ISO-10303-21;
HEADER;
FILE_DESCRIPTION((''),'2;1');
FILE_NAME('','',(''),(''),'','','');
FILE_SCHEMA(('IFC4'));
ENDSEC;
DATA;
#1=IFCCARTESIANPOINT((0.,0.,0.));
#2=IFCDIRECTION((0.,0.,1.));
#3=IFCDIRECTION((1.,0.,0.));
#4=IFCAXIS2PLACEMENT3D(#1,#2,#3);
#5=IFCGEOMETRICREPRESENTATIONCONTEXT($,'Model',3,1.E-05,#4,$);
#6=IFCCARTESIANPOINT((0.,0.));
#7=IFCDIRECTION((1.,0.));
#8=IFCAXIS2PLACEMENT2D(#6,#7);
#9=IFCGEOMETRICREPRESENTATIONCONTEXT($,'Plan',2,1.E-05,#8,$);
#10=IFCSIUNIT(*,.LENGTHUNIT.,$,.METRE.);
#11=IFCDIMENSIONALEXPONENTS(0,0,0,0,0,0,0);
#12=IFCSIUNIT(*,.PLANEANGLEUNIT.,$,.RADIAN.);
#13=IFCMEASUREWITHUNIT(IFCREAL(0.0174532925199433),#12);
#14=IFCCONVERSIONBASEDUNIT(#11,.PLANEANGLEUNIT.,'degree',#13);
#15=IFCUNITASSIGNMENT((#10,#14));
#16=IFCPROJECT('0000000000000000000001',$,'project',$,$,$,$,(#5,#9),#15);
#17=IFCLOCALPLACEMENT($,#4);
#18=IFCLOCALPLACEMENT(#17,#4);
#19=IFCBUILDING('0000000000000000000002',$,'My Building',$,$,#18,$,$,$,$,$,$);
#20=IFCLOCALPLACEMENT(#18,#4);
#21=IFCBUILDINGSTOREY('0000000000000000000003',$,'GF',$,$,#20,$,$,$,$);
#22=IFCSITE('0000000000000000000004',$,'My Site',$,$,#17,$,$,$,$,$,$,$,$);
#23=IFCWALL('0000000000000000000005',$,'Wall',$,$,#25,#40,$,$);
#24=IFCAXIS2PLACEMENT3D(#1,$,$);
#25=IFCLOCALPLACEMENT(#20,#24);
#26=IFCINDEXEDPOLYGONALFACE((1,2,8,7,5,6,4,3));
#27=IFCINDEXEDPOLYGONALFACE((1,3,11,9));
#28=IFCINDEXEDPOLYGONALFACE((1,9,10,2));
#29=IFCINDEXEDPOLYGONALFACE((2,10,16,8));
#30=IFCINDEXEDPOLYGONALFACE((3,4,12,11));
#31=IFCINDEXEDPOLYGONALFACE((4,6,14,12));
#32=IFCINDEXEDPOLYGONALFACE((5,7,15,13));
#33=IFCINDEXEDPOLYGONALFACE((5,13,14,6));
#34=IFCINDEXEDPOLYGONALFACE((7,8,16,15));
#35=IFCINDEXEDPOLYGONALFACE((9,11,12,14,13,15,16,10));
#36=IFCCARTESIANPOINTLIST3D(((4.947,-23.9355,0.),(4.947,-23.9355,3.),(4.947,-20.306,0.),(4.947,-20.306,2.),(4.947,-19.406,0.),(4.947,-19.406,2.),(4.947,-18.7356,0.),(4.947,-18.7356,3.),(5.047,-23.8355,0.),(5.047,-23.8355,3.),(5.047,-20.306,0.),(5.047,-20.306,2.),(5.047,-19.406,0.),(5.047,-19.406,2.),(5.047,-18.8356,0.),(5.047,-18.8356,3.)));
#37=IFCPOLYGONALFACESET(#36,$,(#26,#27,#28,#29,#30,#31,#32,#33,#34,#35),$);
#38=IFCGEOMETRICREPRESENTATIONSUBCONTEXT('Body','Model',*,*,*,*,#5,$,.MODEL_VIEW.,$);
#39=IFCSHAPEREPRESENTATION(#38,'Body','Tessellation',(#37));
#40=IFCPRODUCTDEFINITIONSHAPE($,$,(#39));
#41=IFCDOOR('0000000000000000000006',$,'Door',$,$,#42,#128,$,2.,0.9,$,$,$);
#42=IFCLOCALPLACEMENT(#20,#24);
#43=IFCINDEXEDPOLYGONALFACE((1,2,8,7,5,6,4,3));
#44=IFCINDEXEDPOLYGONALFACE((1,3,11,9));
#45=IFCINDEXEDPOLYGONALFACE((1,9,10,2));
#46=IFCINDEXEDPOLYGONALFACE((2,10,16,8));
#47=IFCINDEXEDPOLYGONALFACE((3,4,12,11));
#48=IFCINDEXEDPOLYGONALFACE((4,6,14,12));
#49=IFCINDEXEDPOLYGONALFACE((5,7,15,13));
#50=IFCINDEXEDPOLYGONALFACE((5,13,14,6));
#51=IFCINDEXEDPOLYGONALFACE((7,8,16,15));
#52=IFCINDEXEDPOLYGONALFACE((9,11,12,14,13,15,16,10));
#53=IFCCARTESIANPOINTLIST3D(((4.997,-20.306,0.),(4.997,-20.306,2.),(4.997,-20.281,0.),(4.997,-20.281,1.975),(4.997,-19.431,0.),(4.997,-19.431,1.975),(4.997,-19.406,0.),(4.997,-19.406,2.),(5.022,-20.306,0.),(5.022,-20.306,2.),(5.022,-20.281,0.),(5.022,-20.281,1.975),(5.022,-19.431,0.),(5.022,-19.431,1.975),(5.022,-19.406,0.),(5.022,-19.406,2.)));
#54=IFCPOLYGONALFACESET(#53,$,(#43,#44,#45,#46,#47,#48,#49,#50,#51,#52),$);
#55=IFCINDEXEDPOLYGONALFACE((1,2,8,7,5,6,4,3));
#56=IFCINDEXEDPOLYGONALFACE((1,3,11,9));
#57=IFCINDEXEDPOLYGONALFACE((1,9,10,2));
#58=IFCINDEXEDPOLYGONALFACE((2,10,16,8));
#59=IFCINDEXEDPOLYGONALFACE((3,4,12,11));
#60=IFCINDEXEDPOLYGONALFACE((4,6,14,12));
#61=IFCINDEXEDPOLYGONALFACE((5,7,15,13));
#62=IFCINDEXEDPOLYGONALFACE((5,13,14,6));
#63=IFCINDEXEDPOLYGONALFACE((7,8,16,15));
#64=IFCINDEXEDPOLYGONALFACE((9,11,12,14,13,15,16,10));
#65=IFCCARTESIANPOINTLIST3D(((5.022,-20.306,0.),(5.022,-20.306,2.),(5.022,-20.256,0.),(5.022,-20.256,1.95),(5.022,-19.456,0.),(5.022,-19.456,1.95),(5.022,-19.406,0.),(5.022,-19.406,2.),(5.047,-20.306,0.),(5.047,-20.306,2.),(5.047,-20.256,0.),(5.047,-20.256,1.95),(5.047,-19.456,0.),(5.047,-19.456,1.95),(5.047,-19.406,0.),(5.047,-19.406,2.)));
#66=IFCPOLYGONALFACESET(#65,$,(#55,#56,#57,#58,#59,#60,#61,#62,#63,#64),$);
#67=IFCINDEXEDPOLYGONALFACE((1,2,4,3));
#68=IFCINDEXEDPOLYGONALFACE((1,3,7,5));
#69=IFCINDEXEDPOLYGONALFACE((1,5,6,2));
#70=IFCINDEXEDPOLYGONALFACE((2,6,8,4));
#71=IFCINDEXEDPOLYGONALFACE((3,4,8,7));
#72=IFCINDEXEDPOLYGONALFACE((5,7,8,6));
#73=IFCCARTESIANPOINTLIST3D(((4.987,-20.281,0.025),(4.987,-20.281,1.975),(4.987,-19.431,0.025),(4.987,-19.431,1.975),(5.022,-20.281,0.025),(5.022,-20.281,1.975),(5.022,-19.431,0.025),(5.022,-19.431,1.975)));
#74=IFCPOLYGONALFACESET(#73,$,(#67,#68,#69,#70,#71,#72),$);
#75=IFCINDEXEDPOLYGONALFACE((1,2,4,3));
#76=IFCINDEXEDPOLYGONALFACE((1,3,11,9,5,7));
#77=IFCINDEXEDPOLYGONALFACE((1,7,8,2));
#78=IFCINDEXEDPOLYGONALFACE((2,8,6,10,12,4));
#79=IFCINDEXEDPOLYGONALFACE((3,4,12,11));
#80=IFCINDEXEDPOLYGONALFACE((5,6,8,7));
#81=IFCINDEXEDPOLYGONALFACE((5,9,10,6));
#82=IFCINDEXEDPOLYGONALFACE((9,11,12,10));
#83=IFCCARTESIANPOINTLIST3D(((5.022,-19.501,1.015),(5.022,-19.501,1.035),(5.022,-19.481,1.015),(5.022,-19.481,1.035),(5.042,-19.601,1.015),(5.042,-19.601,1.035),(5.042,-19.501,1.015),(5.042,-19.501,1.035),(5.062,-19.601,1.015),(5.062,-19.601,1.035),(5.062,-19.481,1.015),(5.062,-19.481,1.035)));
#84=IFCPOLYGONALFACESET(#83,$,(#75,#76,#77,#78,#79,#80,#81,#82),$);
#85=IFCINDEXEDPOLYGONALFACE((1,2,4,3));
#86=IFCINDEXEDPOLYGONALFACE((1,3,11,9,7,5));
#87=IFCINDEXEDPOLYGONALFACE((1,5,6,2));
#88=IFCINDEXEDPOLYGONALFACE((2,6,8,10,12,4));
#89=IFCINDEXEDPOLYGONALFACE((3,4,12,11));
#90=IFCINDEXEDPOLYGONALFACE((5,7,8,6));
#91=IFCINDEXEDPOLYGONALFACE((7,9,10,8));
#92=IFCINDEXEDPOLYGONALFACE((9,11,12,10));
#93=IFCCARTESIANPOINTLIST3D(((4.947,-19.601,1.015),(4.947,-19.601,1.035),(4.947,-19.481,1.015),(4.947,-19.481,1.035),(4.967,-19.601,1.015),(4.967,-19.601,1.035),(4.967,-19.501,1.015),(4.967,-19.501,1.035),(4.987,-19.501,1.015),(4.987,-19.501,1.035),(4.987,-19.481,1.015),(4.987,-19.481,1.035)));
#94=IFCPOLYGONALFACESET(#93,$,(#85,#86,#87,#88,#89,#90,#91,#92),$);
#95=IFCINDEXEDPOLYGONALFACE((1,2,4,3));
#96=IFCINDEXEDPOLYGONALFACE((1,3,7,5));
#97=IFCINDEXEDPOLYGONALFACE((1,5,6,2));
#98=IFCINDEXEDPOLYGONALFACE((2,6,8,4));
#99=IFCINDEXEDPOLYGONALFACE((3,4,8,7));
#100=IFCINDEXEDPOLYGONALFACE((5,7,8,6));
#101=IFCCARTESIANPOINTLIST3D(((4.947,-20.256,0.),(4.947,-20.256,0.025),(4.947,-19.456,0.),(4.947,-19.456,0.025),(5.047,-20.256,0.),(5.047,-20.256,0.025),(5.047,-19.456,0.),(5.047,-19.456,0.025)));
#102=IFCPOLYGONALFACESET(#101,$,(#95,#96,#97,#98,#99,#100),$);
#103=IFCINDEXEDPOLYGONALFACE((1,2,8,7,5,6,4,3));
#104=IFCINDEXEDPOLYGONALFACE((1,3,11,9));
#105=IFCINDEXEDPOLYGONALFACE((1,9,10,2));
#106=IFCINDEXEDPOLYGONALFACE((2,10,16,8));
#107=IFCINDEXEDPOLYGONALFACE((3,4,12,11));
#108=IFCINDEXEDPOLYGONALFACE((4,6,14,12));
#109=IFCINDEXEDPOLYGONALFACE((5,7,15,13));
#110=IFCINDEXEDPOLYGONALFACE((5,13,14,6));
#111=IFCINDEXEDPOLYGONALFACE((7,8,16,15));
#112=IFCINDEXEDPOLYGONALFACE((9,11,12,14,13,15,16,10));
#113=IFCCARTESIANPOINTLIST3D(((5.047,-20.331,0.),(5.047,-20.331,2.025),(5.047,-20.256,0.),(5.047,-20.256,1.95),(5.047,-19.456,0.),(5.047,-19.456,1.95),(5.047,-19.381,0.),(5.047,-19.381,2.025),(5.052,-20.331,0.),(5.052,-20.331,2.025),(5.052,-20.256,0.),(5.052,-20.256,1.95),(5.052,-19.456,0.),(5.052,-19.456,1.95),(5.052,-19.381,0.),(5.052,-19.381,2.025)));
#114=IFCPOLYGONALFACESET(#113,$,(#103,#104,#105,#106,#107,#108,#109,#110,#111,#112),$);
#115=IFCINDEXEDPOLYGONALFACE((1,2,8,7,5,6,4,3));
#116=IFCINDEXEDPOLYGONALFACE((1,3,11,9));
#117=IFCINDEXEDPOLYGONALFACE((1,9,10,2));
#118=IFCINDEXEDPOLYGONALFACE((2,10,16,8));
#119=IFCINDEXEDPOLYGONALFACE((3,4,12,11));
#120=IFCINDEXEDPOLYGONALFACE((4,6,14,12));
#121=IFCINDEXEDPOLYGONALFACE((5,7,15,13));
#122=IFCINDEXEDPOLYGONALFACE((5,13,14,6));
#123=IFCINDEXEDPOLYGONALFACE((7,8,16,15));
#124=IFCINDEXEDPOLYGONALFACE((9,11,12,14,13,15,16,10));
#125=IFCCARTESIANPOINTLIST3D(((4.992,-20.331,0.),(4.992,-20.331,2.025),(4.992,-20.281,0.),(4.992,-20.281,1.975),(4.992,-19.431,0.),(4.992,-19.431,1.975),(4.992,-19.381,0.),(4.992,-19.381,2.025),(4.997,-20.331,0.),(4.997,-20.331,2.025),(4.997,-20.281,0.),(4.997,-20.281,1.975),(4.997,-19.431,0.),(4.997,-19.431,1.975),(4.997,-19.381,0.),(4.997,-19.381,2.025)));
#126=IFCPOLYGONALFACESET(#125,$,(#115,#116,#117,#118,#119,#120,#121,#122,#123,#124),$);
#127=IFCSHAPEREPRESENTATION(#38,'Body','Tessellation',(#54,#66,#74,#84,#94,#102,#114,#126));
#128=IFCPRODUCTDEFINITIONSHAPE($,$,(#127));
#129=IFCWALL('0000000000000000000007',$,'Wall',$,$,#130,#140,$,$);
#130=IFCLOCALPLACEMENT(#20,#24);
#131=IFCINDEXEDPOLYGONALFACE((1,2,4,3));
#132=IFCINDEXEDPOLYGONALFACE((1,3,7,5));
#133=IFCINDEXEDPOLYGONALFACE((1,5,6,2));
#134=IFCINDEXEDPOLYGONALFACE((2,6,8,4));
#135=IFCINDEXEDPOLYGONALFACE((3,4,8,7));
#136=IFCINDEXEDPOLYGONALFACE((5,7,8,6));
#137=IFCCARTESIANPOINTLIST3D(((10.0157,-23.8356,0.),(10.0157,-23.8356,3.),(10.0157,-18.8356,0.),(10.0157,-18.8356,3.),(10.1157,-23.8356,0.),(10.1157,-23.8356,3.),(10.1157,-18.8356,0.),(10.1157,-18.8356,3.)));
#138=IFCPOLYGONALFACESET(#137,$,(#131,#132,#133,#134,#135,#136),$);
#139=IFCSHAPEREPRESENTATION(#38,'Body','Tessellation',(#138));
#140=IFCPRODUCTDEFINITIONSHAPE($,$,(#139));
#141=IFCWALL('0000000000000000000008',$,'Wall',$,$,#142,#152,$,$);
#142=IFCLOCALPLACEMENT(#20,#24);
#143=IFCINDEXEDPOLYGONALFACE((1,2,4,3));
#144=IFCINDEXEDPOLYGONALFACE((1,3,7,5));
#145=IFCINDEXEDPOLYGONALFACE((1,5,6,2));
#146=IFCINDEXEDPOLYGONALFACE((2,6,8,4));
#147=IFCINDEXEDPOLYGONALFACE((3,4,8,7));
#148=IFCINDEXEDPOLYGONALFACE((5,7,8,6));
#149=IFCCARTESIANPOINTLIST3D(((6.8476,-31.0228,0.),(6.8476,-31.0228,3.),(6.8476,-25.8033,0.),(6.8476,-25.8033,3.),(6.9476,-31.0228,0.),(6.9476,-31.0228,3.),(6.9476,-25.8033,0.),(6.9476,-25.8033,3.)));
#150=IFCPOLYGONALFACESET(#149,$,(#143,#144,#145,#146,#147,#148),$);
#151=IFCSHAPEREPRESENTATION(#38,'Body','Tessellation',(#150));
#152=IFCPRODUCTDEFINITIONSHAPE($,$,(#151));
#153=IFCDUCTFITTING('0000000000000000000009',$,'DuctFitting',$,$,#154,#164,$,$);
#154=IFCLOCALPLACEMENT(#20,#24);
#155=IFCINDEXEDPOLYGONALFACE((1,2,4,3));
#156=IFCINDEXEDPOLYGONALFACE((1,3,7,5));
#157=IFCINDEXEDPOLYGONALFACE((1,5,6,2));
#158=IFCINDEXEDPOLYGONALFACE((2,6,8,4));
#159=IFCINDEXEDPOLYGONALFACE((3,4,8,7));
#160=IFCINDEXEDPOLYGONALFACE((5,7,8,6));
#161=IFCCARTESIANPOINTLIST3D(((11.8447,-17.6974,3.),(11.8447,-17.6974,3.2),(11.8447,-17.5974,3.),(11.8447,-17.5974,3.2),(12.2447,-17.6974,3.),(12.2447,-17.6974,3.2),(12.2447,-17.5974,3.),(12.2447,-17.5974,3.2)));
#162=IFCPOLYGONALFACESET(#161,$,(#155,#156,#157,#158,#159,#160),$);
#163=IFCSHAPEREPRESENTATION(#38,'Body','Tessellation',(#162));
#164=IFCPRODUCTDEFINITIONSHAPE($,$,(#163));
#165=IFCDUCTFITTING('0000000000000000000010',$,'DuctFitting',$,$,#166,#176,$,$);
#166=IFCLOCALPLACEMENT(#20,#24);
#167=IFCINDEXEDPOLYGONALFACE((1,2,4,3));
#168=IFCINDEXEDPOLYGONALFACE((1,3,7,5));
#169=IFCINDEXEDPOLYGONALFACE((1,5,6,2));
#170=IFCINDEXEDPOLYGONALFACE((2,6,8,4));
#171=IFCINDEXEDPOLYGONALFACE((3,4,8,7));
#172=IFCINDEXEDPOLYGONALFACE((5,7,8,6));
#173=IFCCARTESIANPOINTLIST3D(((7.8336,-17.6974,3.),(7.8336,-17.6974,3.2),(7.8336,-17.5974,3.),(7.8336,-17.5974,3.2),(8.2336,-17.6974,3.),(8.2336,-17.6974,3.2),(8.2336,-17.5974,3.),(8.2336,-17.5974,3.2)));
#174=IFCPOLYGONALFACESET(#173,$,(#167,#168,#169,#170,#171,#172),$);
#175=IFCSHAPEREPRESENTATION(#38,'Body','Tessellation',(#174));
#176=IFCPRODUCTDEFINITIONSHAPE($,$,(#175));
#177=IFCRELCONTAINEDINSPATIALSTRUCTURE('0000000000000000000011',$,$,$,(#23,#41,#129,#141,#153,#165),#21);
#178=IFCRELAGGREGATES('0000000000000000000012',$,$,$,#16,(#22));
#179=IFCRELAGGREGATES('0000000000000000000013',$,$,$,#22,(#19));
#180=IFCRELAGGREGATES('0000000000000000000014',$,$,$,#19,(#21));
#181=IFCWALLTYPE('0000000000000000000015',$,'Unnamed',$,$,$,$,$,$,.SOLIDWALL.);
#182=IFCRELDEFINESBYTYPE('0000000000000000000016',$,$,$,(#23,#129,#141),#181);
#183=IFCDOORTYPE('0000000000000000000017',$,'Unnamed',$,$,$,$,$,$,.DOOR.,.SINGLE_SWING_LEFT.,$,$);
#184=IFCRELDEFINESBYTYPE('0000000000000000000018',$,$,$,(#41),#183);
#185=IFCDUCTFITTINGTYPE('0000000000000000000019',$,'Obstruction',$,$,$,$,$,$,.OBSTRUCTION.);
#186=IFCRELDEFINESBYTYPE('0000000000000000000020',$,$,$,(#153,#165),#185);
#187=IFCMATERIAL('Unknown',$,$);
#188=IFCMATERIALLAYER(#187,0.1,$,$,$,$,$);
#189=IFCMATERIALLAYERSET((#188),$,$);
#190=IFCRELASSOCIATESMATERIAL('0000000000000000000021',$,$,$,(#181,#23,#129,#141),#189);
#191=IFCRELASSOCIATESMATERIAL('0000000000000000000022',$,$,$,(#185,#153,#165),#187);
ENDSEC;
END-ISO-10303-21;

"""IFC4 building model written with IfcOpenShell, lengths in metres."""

from ifc_helpers import new_model, entity, si_unit, converted_unit, frame, origin_with_axes, origin_2d_with_axis, place, context, subcontext, project, spatial, line, indexed_curve, rectangle, outline, extrude, shape, source, transform, mapped, material, layer, layer_set, layer_usage, material_profile, profile_set, profile_usage, type_object, type_shapes, element, fill, save


model = new_model("IFC4")

# Units and contexts
model_context = context("Model", 3, precision=1e-05, world=origin_with_axes())
plan_context = context("Plan", 2, precision=1e-05, world=origin_2d_with_axis())
body_context_1 = subcontext(model_context, "Body", "Model", "MODEL_VIEW")
body_context_2 = subcontext(plan_context, "Body", "Plan", "PLAN_VIEW")
ifc_project = project(units=[si_unit("LENGTHUNIT", "METRE"), converted_unit("PLANEANGLEUNIT", "degree", entity("IfcReal", 0.0174532925199433), si_unit("PLANEANGLEUNIT", "RADIAN"), dimensions=[0, 0, 0, 0, 0, 0, 0])], contexts=[model_context, plan_context])

# Site, building, storey
site_placement = place(None, origin_with_axes())
site = spatial("IfcSite", under=ifc_project, at=site_placement, Name="My Site")
building_placement = place(site_placement, origin_with_axes())
building = spatial("IfcBuilding", under=site, at=building_placement, Name="My Building")
storey_placement = place(building_placement, origin_with_axes())
storey = spatial("IfcBuildingStorey", under=building, at=storey_placement, Name="GF")

# Shared definitions
ifc_material = material(Name="Unknown")
ifc_layer = layer(ifc_material, 0.1)
ifc_layer_set = layer_set([ifc_layer])
wall_type = type_object("IfcWallType", Name="Unnamed", PredefinedType="SOLIDWALL", material=ifc_layer_set)

# Shared definitions
shared_shape_1 = source(origin_with_axes(), body_context_1, "Body", "SweptSolid", [
    extrude(outline(indexed_curve([(0.0, 0.0), (0.9, 0.0), (0.9, 2.0), (0.0, 2.0)], segments=[line(1, 2, 3, 4, 1)])), frame((0.0, -0.6, 0.0), z_axis=(0.0, -1.0, 0.0), x_axis=(1.0, 0.0, 0.0)), (0.0, 0.0, -1.0), 1.2),
])
door_type = type_object("IfcDoorType", Name="Unnamed", OperationType="SINGLE_SWING_LEFT", PredefinedType="DOOR")
shared_shape_2 = source(origin_with_axes(), body_context_1, "Body", "SweptSolid", [
    extrude(outline(indexed_curve([(0.0, 0.0), (0.0, 2.0), (0.9, 2.0), (0.9, 0.0), (0.875, 0.0), (0.875, 1.975), (0.025, 1.975), (0.025, 0.0)], segments=[line(1, 2, 3, 4, 5, 6, 7, 8, 1)])), frame((0.0, 0.025, 0.0), z_axis=(0.0, -1.0, 0.0), x_axis=(1.0, 0.0, 0.0)), (0.0, 0.0, -1.0), 0.025),
    extrude(outline(indexed_curve([(0.0, 0.0), (0.0, 2.0), (0.9, 2.0), (0.9, 0.0), (0.85, 0.0), (0.85, 1.95), (0.05, 1.95), (0.05, 0.0)], segments=[line(1, 2, 3, 4, 5, 6, 7, 8, 1)])), frame((0.0, 0.0, 0.0), z_axis=(0.0, -1.0, 0.0), x_axis=(1.0, 0.0, 0.0)), (0.0, 0.0, -1.0), 0.025),
    extrude(outline(indexed_curve([(0.0, 0.0), (0.85, 0.0), (0.85, 0.035), (0.0, 0.035)], segments=[line(1, 2, 3, 4, 1)])), frame((0.025, 0.025, 0.025), z_axis=(0.0, 0.0, 1.0), x_axis=(1.0, 0.0, 0.0)), (0.0, 0.0, 1.0), 1.95),
    extrude(outline(indexed_curve([(0.0, 0.0), (0.0, -0.04), (-0.12, -0.04), (-0.12, -0.02), (-0.02, -0.02), (-0.02, 0.0)], segments=[line(1, 2, 3, 4, 5, 6, 1)])), frame((0.825, 0.025, 1.015), z_axis=(0.0, 0.0, 1.0), x_axis=(1.0, 0.0, 0.0)), (0.0, 0.0, 1.0), 0.02),
    extrude(outline(indexed_curve([(0.0, 0.0), (0.0, 0.04), (-0.12, 0.04), (-0.12, 0.02), (-0.02, 0.02), (-0.02, 0.0)], segments=[line(1, 2, 3, 4, 5, 6, 1)])), frame((0.825, 0.06, 1.015), z_axis=(0.0, 0.0, 1.0), x_axis=(1.0, 0.0, 0.0)), (0.0, 0.0, 1.0), 0.02),
    extrude(outline(indexed_curve([(0.0, 0.0), (0.8, 0.0), (0.8, 0.1), (0.0, 0.1)], segments=[line(1, 2, 3, 4, 1)])), frame((0.05, 0.0, 0.0), z_axis=(0.0, 0.0, 1.0), x_axis=(1.0, 0.0, 0.0)), (0.0, 0.0, 1.0), 0.025),
    extrude(outline(indexed_curve([(0.0, 0.0), (0.0, 2.025), (0.95, 2.025), (0.95, 0.0), (0.875, 0.0), (0.875, 1.95), (0.075, 1.95), (0.075, 0.0)], segments=[line(1, 2, 3, 4, 5, 6, 7, 8, 1)])), frame((-0.025, -0.005, 0.0), z_axis=(0.0, -1.0, 0.0), x_axis=(1.0, 0.0, 0.0)), (0.0, 0.0, -1.0), 0.005),
    extrude(outline(indexed_curve([(0.0, 0.0), (0.0, 2.025), (0.95, 2.025), (0.95, 0.0), (0.9, 0.0), (0.9, 1.975), (0.05, 1.975), (0.05, 0.0)], segments=[line(1, 2, 3, 4, 5, 6, 7, 8, 1)])), frame((-0.025, 0.05, 0.0), z_axis=(0.0, -1.0, 0.0), x_axis=(1.0, 0.0, 0.0)), (0.0, 0.0, -1.0), 0.005),
])
shared_shape_3 = source(origin_with_axes(), body_context_2, "Body", "Curve2D", [
    entity("IfcIndexedPolyCurve", entity("IfcCartesianPointList2D", [[0.0, 0.0], [0.0, 0.05], [0.025, 0.05], [0.025, 0.025], [0.05, 0.025], [0.05, 0.0]]), [entity("IfcLineIndex", [1, 2, 3, 4, 5, 6, 1])]),
    entity("IfcIndexedPolyCurve", entity("IfcCartesianPointList2D", [[0.9, 0.0], [0.9, 0.05], [0.875, 0.05], [0.875, 0.025], [0.85, 0.025], [0.85, 0.0]]), [entity("IfcLineIndex", [1, 2, 3, 4, 5, 6, 1])]),
    entity("IfcTrimmedCurve", entity("IfcEllipse", entity("IfcAxis2Placement2D", entity("IfcCartesianPoint", [0.06, 0.05]), entity("IfcDirection", [1.0, 0.0])), 0.815, 0.85), [entity("IfcCartesianPoint", [0.875, 0.05])], [entity("IfcCartesianPoint", [0.06, 0.9])], True, "CARTESIAN"),
    entity("IfcIndexedPolyCurve", entity("IfcCartesianPointList2D", [[0.025, 0.05], [0.06, 0.05], [0.06, 0.9], [0.025, 0.9]]), [entity("IfcLineIndex", [1, 2, 3, 4, 1])]),
])
type_shapes(door_type, [shared_shape_2, shared_shape_3])

# Wall, opening, door
ifc_layer_usage_1 = layer_usage(ifc_layer_set, "AXIS2", "POSITIVE", 0.0)
wall_1_placement = place(storey_placement, frame((5.047, -23.8355, 0.0), z_axis=(0.0, 0.0, 1.0), x_axis=(0.0, 1.0, 0.0)))
wall_1 = element("IfcWall", 1, at=wall_1_placement, inside=storey, type_object=wall_type, material=ifc_layer_usage_1, Name="Wall", context=body_context_1, shape_type="SweptSolid", body=[
    extrude(outline(indexed_curve([(0.0, 0.0), (-0.1, 0.1), (5.1, 0.1), (5.0, 0.0)], segments=[line(1, 2, 3, 4, 1)])), origin_with_axes(), (0.0, 0.0, 1.0), 3.0),
])
opening_1_placement = place(wall_1_placement, frame((3.5295, 0.0, 0.0), z_axis=(0.0, 0.0, 1.0), x_axis=(1.0, 0.0, 0.0)))
opening_1 = element("IfcOpeningElement", 2, at=opening_1_placement, cuts=wall_1, PredefinedType="OPENING", context=body_context_1, shape_type="MappedRepresentation", body=[
    mapped(shared_shape_1, transform((0.0, 0.0, 0.0), x_axis=(1.0, 0.0, 0.0), y_axis=(0.0, 1.0, 0.0), z_axis=(0.0, 0.0, 1.0), scale=1.0)),
])
door_1_placement = place(opening_1_placement, frame((0.0, 0.0, 0.0), z_axis=(0.0, 0.0, 1.0), x_axis=(1.0, 0.0, 0.0)))
door_1 = element("IfcDoor", 3, at=door_1_placement, inside=storey, type_object=door_type, Name="Door", OverallHeight=2.0, OverallWidth=0.9, shapes=[
    shape(body_context_1, "Body", "MappedRepresentation", [mapped(shared_shape_2, transform((0.0, 0.0, 0.0), x_axis=(1.0, 0.0, 0.0), y_axis=(0.0, 1.0, 0.0), z_axis=(0.0, 0.0, 1.0), scale=1.0))]),
    shape(body_context_2, "Body", "MappedRepresentation", [mapped(shared_shape_3, transform((0.0, 0.0, 0.0), x_axis=(1.0, 0.0, 0.0), y_axis=(0.0, 1.0, 0.0), z_axis=(0.0, 0.0, 1.0), scale=1.0))]),
])
fill(opening_1, door_1)

# Walls
ifc_layer_usage_2 = layer_usage(ifc_layer_set, "AXIS2", "POSITIVE", 0.0)
wall_2_placement = place(storey_placement, frame((10.0157, -18.8356, 0.0), z_axis=(0.0, 0.0, 1.0), x_axis=(0.0, -1.0, 0.0)))
element("IfcWall", 4, at=wall_2_placement, inside=storey, type_object=wall_type, material=ifc_layer_usage_2, Name="Wall", context=body_context_1, shape_type="SweptSolid", body=[
    extrude(outline(indexed_curve([(0.0, 0.0), (0.0, 0.1), (5.0, 0.1), (5.0, 0.0)], segments=[line(1, 2, 3, 4, 1)])), origin_with_axes(), (0.0, 0.0, 1.0), 3.0),
])
ifc_layer_usage_3 = layer_usage(ifc_layer_set, "AXIS2", "POSITIVE", 0.0)
wall_3_placement = place(storey_placement, frame((6.8476, -25.8033, 0.0), z_axis=(0.0, 0.0, 1.0), x_axis=(0.0, -1.0, 0.0)))
element("IfcWall", 5, at=wall_3_placement, inside=storey, type_object=wall_type, material=ifc_layer_usage_3, Name="Wall", context=body_context_1, shape_type="SweptSolid", body=[
    extrude(outline(indexed_curve([(0.0, 0.0), (0.0, 0.1), (5.2195, 0.1), (5.2195, 0.0)], segments=[line(1, 2, 3, 4, 1)])), origin_with_axes(), (0.0, 0.0, 1.0), 3.0),
])

# Duct fittings
ifc_material_profile = material_profile(ifc_material, rectangle(XDim=0.4, YDim=0.2))
ifc_profile_set = profile_set([ifc_material_profile])
ifc_profile_usage_1 = profile_usage(ifc_profile_set, cardinal=5)
duct_fitting_type = type_object("IfcDuctFittingType", Name="Obstruction", PredefinedType="OBSTRUCTION", material=ifc_profile_set)
duct_fitting_1_placement = place(storey_placement, frame((12.0447, -17.6974, 3.1), z_axis=(0.0, 1.0, -0.000003), x_axis=(-1.0, 0.0, 0.0)))
element("IfcDuctFitting", 6, at=duct_fitting_1_placement, inside=storey, type_object=duct_fitting_type, material=ifc_profile_usage_1, Name="DuctFitting", context=body_context_1, shape_type="SweptSolid", body=[
    extrude(rectangle(XDim=0.4, YDim=0.2), origin_with_axes(), (0.0, 0.0, 1.0), 0.1),
])
ifc_profile_usage_2 = profile_usage(ifc_profile_set, cardinal=5)
duct_fitting_2_placement = place(storey_placement, frame((8.0336, -17.6974, 3.1), z_axis=(0.0, 1.0, -0.000003), x_axis=(-1.0, 0.0, 0.0)))
element("IfcDuctFitting", 7, at=duct_fitting_2_placement, inside=storey, type_object=duct_fitting_type, material=ifc_profile_usage_2, Name="DuctFitting", context=body_context_1, shape_type="SweptSolid", body=[
    extrude(rectangle(XDim=0.4, YDim=0.2), origin_with_axes(), (0.0, 0.0, 1.0), 0.1),
])

save(model, "model.ifc")
